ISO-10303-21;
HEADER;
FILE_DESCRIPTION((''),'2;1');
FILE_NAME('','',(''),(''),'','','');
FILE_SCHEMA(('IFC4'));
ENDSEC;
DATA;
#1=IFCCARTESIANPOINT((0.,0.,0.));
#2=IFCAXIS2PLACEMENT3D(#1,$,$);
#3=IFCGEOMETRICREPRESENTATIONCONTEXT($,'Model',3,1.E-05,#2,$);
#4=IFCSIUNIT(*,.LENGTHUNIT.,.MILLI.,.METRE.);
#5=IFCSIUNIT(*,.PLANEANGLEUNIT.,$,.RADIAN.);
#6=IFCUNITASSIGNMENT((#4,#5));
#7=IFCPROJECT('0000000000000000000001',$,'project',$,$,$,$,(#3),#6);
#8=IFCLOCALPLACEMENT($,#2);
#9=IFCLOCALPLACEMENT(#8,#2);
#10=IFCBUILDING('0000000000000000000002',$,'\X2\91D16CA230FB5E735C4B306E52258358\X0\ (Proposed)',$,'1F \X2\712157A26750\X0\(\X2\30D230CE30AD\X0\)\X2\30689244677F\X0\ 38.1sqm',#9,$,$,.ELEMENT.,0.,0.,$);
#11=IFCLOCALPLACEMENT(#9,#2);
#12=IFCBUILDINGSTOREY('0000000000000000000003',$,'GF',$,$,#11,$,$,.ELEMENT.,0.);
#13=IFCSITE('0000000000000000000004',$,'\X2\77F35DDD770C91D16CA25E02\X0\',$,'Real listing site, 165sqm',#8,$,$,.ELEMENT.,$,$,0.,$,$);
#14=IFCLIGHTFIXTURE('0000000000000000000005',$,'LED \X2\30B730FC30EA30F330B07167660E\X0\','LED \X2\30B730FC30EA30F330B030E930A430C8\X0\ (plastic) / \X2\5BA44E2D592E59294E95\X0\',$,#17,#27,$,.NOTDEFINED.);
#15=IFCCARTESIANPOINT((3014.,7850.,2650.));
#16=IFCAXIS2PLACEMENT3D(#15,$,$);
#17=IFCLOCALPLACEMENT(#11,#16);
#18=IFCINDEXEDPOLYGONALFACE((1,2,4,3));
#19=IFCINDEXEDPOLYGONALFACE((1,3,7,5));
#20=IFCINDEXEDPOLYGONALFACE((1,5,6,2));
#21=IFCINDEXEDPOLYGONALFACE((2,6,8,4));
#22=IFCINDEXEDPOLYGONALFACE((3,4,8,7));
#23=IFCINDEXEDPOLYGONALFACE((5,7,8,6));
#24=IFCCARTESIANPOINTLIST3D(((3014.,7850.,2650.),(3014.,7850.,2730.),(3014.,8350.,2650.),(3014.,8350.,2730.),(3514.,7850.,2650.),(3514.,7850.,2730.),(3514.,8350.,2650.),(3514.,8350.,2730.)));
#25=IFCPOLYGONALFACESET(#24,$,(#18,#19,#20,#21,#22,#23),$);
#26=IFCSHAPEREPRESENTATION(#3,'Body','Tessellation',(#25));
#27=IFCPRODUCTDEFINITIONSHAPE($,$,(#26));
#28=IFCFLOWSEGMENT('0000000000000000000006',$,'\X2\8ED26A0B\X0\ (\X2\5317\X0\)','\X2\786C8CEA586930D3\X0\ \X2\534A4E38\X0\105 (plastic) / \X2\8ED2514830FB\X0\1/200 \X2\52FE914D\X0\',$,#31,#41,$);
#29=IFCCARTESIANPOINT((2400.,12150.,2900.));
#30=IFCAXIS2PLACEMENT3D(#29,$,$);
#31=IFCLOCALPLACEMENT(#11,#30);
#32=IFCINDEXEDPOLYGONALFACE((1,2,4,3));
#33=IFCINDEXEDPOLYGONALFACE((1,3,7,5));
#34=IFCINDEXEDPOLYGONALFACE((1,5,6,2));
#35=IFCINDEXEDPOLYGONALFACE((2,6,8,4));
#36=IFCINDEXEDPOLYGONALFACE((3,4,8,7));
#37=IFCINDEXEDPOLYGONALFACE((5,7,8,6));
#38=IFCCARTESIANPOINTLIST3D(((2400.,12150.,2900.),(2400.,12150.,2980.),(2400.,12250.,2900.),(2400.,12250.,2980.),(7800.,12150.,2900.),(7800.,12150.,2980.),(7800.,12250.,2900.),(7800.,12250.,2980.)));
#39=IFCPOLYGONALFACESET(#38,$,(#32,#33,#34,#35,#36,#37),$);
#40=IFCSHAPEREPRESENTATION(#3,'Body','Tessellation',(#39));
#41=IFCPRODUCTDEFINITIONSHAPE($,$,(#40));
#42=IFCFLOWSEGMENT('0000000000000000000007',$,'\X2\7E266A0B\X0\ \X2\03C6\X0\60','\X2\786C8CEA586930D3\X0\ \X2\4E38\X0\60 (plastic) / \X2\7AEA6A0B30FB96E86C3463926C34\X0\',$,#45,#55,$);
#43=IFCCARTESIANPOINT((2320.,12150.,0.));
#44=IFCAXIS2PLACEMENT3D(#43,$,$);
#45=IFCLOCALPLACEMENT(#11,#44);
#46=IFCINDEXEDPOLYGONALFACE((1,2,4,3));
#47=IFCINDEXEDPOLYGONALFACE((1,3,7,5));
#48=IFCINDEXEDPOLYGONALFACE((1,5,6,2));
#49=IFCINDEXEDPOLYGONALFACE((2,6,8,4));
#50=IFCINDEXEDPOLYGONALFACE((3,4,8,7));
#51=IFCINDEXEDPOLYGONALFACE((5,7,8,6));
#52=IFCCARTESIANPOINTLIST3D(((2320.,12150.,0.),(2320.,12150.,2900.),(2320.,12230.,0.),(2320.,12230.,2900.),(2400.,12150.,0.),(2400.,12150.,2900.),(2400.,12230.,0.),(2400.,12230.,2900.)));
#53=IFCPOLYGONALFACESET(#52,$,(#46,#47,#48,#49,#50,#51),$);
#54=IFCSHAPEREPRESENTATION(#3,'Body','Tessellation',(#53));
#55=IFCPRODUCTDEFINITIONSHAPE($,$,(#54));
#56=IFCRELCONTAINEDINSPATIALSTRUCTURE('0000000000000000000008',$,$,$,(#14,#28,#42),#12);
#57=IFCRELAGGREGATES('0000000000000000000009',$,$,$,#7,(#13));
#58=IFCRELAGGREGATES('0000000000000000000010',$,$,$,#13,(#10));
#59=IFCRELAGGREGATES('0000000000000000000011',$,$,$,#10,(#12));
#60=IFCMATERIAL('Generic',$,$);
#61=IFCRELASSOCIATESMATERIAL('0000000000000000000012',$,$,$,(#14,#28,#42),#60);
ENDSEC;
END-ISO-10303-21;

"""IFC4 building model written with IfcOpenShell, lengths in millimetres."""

from ifc_helpers import new_model, si_unit, frame, frame_2d, origin, place, context, project, spatial, rectangle, extrude, material, element, save


model = new_model("IFC4")

# Units and contexts
model_context = context("Model", 3, precision=1e-05, world=origin())
ifc_project = project(units=[si_unit("LENGTHUNIT", "METRE", prefix="MILLI"), si_unit("PLANEANGLEUNIT", "RADIAN")], contexts=[model_context])

# Site, building, storey
site_placement = place(None, origin())
site = spatial("IfcSite", under=ifc_project, at=site_placement, Name="石川県金沢市", ObjectType="Real listing site, 165sqm", CompositionType="ELEMENT", RefElevation=0.0)
building_placement = place(site_placement, origin())
building = spatial("IfcBuilding", under=site, at=building_placement, Name="金沢・平屋の別荘 (Proposed)", ObjectType="1F 無垢材(ヒノキ)と鉄板 38.1sqm", CompositionType="ELEMENT", ElevationOfRefHeight=0.0, ElevationOfTerrain=0.0)
storey_placement = place(building_placement, origin())
storey = spatial("IfcBuildingStorey", under=building, at=storey_placement, Name="GF", CompositionType="ELEMENT", Elevation=0.0)

# Shared definitions
ifc_material_1 = material(Name="Generic")

# Light fixture
light_fixture_placement = place(storey_placement, frame((3014.0, 7850.0, 2650.0)))
element("IfcLightFixture", 1, at=light_fixture_placement, inside=storey, material=ifc_material_1, Name="LED シーリング照明", Description="LED シーリングライト (plastic) / 室中央天井", PredefinedType="NOTDEFINED", context=model_context, shape_type="SweptSolid", body=[
    extrude(rectangle(XDim=500.0, YDim=500.0, at=frame_2d((250.0, 250.0))), frame((3014.0, 7850.0, 2650.0)), (0.0, 0.0, 1.0), 80.0),
])

# Flow segments
flow_segment_1_placement = place(storey_placement, frame((2400.0, 12150.0, 2900.0)))
element("IfcFlowSegment", 2, at=flow_segment_1_placement, inside=storey, material=ifc_material_1, Name="軒樋 (北)", Description="硬質塩ビ 半丸105 (plastic) / 軒先・1/200 勾配", context=model_context, shape_type="SweptSolid", body=[
    extrude(rectangle(XDim=5400.0, YDim=100.0, at=frame_2d((2700.0, 50.0))), frame((2400.0, 12150.0, 2900.0)), (0.0, 0.0, 1.0), 80.0),
])
flow_segment_2_placement = place(storey_placement, frame((2320.0, 12150.0, 0.0)))
element("IfcFlowSegment", 3, at=flow_segment_2_placement, inside=storey, material=ifc_material_1, Name="縦樋 φ60", Description="硬質塩ビ 丸60 (plastic) / 竪樋・雨水排水", context=model_context, shape_type="SweptSolid", body=[
    extrude(rectangle(XDim=80.0, YDim=80.0, at=frame_2d((40.0, 40.0))), frame((2320.0, 12150.0, 0.0)), (0.0, 0.0, 1.0), 2900.0),
])

save(model, "model.ifc")
